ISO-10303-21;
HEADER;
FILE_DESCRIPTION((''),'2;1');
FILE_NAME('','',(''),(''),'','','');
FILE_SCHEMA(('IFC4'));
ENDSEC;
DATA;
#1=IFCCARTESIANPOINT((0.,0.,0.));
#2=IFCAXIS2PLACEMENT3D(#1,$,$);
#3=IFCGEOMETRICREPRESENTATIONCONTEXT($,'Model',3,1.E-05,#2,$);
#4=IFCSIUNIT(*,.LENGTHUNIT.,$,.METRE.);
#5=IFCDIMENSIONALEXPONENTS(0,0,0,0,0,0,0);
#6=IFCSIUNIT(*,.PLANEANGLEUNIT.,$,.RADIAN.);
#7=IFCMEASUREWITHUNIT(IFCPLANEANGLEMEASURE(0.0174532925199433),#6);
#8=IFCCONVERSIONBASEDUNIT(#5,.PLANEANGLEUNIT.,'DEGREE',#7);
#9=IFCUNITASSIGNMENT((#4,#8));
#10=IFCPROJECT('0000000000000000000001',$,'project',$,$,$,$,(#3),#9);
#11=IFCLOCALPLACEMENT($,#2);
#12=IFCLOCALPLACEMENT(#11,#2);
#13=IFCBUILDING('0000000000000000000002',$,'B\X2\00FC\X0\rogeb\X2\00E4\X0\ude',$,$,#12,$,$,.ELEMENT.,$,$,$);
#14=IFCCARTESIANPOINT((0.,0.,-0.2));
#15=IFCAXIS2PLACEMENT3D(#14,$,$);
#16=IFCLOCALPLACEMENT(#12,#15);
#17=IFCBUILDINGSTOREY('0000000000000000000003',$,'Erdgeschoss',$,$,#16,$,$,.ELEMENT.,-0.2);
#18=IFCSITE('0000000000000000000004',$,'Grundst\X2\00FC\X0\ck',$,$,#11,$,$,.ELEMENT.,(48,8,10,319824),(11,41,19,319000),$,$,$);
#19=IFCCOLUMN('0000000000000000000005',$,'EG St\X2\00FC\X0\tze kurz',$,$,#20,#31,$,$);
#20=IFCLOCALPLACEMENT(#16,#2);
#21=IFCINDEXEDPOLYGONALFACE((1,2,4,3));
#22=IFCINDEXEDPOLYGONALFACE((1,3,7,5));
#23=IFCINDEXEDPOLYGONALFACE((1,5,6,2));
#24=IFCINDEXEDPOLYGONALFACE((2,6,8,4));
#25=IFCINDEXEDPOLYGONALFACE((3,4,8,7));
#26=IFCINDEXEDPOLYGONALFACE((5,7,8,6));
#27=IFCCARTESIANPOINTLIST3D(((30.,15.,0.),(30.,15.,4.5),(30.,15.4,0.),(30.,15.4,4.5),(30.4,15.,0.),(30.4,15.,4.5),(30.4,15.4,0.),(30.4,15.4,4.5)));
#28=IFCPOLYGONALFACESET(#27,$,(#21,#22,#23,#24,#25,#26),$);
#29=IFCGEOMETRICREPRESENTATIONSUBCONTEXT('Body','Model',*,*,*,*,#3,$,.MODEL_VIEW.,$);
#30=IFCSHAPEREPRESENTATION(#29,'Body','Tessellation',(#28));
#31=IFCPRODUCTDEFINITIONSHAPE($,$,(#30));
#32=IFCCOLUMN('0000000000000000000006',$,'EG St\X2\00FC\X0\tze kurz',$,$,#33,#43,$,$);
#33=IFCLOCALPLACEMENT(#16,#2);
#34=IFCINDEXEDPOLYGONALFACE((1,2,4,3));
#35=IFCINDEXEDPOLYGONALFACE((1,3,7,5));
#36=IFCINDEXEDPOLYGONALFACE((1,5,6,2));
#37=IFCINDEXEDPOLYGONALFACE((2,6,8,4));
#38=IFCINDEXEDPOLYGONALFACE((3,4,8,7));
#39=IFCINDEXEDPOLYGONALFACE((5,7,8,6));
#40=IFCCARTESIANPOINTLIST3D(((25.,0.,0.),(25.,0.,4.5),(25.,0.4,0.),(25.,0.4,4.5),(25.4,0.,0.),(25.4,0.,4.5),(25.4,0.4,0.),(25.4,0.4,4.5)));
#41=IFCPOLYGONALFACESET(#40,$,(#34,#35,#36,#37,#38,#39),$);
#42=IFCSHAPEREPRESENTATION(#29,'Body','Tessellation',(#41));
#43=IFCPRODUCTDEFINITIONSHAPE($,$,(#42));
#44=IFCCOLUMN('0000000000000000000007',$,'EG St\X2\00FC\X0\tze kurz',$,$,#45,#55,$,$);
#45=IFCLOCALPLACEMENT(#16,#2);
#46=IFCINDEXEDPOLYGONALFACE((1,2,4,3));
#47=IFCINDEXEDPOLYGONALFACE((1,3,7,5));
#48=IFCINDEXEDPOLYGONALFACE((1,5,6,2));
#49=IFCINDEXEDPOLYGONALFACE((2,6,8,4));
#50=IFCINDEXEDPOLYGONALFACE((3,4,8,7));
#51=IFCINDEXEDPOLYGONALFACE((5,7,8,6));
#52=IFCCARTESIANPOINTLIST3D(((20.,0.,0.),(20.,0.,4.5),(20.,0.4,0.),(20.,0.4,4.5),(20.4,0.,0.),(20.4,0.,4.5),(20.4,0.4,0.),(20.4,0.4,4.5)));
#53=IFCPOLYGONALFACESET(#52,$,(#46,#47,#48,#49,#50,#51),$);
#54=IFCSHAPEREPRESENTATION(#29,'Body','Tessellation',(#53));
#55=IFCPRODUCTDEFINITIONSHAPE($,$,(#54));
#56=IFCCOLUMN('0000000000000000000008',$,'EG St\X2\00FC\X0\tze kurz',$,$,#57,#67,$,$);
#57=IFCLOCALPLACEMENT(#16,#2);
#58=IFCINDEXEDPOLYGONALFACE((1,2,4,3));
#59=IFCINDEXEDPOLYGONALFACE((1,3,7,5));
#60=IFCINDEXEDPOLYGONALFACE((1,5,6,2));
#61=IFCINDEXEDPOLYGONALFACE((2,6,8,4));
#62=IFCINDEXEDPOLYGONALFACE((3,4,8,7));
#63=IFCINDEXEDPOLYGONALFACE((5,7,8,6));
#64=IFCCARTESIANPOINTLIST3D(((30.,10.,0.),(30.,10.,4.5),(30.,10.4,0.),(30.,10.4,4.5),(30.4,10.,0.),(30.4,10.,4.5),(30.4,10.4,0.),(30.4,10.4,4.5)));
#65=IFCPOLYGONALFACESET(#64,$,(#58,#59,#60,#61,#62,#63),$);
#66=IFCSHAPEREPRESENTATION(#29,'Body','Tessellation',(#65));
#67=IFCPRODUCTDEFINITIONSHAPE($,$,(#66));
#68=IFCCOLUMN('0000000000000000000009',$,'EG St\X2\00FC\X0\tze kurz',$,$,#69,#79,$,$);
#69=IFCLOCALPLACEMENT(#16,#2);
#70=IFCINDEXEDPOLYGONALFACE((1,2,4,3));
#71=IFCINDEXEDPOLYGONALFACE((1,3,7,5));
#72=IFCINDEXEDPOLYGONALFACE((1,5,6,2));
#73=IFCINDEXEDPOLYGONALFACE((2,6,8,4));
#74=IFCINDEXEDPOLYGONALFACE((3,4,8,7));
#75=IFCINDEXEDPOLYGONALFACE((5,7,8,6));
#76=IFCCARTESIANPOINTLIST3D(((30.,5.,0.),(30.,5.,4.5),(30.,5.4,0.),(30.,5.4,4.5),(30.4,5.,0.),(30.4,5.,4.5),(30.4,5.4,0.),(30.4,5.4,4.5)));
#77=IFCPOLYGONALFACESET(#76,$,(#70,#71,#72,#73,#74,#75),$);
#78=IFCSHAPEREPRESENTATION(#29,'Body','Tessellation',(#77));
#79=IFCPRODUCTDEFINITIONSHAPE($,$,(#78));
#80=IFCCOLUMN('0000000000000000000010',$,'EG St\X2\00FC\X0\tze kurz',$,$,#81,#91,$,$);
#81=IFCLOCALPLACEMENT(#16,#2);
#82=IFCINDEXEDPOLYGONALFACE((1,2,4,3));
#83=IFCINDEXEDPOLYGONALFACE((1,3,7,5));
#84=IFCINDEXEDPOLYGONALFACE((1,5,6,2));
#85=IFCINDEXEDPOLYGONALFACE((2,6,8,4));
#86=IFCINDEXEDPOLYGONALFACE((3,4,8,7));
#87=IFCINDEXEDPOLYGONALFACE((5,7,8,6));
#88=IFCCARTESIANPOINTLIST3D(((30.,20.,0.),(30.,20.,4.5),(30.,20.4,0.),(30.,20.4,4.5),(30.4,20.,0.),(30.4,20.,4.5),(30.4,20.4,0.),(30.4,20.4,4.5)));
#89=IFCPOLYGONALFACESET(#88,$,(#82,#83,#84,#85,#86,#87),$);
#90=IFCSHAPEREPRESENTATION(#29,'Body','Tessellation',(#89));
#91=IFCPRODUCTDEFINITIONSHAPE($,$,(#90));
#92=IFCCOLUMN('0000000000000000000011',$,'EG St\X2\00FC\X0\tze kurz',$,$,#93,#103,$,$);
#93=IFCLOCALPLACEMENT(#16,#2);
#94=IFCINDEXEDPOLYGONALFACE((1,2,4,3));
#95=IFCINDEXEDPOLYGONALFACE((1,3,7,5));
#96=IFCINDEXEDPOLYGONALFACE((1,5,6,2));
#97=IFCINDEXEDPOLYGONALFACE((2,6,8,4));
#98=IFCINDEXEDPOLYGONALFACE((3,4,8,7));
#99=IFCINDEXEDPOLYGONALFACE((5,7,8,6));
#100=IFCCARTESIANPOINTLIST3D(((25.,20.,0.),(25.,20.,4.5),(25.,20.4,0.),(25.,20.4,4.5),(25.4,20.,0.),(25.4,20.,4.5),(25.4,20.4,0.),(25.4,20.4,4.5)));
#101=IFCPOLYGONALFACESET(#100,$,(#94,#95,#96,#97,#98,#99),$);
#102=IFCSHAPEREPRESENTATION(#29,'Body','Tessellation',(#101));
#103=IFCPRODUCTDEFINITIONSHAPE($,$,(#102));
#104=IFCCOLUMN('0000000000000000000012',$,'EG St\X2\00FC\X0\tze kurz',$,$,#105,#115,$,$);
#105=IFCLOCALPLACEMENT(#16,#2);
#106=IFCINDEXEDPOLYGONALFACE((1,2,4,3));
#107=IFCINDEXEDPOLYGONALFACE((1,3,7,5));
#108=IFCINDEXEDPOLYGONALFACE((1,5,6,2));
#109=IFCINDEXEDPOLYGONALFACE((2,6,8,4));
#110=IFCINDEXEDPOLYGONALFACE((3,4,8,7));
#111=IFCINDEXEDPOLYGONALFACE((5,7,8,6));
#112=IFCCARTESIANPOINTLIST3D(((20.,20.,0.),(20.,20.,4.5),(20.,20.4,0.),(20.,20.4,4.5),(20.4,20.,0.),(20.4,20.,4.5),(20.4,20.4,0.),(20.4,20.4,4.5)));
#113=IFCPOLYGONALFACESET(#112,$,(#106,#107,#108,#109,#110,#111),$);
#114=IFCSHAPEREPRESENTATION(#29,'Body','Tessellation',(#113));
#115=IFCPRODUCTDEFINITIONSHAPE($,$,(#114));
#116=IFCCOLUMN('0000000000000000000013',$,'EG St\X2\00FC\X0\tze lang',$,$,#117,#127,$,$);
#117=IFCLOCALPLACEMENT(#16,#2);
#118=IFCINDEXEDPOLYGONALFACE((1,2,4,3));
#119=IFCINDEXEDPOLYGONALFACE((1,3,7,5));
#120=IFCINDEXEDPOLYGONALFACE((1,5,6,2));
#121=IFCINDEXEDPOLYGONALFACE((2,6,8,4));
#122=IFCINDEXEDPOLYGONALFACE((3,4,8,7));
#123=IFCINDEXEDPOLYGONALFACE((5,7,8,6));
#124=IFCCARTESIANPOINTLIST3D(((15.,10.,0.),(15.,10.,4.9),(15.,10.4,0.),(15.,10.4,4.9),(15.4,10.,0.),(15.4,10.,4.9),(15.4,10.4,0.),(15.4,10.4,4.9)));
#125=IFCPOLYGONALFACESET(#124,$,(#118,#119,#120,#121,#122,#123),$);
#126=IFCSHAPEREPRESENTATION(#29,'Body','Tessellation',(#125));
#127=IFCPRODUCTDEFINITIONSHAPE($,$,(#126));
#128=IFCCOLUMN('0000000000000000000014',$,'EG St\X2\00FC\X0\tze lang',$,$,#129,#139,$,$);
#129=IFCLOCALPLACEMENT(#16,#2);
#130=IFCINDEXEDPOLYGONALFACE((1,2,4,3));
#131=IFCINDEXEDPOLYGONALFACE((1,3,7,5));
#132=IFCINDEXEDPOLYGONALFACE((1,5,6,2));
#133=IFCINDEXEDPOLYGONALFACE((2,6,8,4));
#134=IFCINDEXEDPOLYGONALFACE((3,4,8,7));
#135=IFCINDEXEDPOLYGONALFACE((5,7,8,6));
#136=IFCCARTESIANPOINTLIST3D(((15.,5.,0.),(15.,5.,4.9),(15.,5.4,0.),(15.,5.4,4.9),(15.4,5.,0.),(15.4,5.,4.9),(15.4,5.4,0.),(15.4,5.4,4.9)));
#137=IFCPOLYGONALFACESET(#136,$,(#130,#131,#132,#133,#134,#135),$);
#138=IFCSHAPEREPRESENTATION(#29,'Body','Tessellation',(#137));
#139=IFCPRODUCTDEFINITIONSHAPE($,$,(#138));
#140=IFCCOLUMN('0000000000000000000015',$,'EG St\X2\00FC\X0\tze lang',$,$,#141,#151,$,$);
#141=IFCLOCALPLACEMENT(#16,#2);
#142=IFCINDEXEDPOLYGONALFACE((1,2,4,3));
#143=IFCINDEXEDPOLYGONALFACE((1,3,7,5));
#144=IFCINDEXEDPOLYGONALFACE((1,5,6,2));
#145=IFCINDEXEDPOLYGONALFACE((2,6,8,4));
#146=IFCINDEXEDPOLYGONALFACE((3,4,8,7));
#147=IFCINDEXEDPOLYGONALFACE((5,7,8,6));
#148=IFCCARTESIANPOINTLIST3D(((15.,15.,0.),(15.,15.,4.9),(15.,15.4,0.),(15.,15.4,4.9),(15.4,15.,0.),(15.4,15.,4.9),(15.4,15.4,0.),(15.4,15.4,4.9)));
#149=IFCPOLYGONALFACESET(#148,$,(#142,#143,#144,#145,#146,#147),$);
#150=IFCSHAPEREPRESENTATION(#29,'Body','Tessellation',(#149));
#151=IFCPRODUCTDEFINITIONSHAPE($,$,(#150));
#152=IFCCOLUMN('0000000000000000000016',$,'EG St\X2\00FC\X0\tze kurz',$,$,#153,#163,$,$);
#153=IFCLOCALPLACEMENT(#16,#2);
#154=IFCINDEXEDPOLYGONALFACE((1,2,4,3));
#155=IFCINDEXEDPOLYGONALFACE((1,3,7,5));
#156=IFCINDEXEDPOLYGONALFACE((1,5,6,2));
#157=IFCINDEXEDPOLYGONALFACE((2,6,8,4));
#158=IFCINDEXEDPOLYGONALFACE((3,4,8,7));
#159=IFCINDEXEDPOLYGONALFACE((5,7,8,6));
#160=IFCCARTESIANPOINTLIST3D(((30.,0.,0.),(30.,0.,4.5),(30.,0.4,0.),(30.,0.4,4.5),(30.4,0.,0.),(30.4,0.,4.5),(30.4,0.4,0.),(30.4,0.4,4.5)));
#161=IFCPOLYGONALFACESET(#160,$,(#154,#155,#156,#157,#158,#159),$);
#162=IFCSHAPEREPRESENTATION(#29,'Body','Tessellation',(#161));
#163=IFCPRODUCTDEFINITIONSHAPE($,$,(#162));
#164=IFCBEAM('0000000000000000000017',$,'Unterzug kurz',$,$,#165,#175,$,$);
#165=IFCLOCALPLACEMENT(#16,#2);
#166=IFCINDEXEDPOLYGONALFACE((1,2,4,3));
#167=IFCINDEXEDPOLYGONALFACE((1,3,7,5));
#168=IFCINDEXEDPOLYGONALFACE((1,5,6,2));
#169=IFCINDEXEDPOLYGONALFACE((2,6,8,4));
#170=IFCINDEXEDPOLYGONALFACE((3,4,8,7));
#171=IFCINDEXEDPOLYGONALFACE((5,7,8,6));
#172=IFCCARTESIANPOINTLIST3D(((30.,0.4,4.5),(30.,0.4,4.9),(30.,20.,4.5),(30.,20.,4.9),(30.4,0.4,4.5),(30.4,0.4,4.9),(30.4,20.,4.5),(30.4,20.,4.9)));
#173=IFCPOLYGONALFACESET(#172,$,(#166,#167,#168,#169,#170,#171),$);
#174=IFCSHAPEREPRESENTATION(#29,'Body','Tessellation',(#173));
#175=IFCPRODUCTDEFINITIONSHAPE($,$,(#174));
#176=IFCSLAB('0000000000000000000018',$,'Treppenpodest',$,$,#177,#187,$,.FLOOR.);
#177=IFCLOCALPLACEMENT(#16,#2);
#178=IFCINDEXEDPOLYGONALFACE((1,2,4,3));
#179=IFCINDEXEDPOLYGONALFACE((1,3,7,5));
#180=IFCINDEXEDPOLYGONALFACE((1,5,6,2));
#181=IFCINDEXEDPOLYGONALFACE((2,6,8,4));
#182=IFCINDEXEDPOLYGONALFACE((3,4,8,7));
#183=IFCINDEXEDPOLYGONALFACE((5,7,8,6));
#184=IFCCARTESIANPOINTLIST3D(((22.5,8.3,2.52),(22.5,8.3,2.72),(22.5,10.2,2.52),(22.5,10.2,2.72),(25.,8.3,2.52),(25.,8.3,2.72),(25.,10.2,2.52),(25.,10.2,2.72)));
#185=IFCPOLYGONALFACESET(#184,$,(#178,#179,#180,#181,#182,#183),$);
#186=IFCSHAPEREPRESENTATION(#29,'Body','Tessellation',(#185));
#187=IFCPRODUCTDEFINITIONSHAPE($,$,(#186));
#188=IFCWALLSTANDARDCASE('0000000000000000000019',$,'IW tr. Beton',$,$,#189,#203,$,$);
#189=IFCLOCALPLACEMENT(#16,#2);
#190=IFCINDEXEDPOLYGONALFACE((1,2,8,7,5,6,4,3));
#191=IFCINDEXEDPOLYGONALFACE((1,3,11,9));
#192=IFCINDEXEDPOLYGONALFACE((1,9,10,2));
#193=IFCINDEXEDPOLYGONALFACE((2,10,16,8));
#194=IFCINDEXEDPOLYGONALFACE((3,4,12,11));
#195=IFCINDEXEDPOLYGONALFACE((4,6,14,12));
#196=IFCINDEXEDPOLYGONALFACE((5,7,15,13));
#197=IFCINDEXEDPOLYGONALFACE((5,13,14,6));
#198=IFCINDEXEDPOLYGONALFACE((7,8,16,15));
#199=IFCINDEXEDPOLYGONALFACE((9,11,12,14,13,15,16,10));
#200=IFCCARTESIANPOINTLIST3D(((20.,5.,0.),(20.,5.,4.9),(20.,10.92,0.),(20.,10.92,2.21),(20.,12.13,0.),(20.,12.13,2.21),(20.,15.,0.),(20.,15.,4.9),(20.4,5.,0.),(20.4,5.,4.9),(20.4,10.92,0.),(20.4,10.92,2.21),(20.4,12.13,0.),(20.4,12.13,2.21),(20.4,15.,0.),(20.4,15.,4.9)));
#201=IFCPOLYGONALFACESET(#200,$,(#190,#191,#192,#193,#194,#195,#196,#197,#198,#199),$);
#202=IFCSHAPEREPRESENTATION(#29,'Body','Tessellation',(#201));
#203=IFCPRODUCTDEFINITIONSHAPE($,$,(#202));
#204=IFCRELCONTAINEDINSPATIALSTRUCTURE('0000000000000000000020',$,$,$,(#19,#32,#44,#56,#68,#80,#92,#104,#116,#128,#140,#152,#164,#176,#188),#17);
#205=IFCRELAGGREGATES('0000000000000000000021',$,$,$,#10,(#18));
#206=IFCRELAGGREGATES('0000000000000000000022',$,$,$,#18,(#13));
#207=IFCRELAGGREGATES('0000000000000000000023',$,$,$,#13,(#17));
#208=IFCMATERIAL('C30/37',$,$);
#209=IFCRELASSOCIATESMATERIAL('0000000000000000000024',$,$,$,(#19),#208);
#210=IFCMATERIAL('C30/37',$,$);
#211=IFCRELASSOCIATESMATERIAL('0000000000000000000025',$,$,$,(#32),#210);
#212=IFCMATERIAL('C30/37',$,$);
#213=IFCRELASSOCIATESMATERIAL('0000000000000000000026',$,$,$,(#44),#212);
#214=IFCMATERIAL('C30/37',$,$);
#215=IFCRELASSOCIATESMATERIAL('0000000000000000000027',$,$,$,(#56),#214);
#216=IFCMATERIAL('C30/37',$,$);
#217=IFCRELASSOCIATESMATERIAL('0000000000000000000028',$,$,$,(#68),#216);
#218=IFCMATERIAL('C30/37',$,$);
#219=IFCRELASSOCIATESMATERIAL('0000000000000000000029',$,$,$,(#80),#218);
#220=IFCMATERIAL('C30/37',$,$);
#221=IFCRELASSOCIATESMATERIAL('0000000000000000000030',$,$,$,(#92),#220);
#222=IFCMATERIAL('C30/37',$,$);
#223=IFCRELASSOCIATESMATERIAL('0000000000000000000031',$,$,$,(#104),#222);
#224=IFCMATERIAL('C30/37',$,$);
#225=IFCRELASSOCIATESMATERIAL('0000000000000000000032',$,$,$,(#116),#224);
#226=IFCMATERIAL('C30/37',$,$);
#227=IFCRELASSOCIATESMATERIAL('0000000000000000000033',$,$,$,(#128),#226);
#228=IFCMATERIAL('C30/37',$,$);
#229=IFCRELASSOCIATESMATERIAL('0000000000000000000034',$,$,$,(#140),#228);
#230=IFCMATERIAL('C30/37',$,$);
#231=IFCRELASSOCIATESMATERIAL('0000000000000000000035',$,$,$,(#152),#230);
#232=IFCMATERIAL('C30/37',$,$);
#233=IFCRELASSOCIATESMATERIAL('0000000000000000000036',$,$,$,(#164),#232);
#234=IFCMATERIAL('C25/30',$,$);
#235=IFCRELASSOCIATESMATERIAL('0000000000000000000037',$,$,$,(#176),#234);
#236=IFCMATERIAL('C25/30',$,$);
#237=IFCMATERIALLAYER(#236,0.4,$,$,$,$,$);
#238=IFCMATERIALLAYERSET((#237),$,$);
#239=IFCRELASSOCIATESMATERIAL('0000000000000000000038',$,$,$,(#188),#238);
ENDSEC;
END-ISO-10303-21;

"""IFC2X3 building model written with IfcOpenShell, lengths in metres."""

from ifc_helpers import new_model, entity, si_unit, converted_unit, frame, frame_2d, origin, origin_with_axes, place, context, subcontext, project, spatial, polyline, rectangle, outline, extrude, material, layer, layer_set, layer_usage, element, save


model = new_model("IFC2X3")

# Units and contexts
model_context = context("Model", 3, precision=1e-05, world=origin())
body_context = subcontext(model_context, "Body", "Model", "MODEL_VIEW")
ifc_project = project(units=[si_unit("LENGTHUNIT", "METRE"), converted_unit("PLANEANGLEUNIT", "DEGREE", entity("IfcPlaneAngleMeasure", 0.0174532925199433), si_unit("PLANEANGLEUNIT", "RADIAN"), dimensions=[0, 0, 0, 0, 0, 0, 0])], contexts=[model_context])

# Site, building, storey
site_placement = place(None, origin())
site = spatial("IfcSite", under=ifc_project, at=site_placement, Name="Grundstück", CompositionType="ELEMENT", RefLatitude=(48, 8, 10, 319824), RefLongitude=(11, 41, 19, 319000))
building_placement = place(site_placement, origin())
building = spatial("IfcBuilding", under=site, at=building_placement, Name="Bürogebäude", CompositionType="ELEMENT")
storey_placement = place(building_placement, frame((0.0, 0.0, -0.2)))
storey = spatial("IfcBuildingStorey", under=building, at=storey_placement, Name="Erdgeschoss", CompositionType="ELEMENT", Elevation=-0.2)

# Columns
ifc_material_1 = material(Name="C30/37")
column_1_placement = place(storey_placement, frame((30.0, 15.0, 0.0)))
element("IfcColumn", 1, at=column_1_placement, inside=storey, material=ifc_material_1, Name="EG Stütze kurz", context=body_context, shape_type="SweptSolid", body=[
    extrude(rectangle(XDim=0.4, YDim=0.4, at=frame_2d((0.2, 0.2), x_axis=(1.0, 0.0))), origin_with_axes(), (0.0, 0.0, 1.0), 4.5),
])
ifc_material_2 = material(Name="C30/37")
column_2_placement = place(storey_placement, frame((25.0, 0.0, 0.0)))
element("IfcColumn", 2, at=column_2_placement, inside=storey, material=ifc_material_2, Name="EG Stütze kurz", context=body_context, shape_type="SweptSolid", body=[
    extrude(rectangle(XDim=0.4, YDim=0.4, at=frame_2d((0.2, 0.2), x_axis=(1.0, 0.0))), origin_with_axes(), (0.0, 0.0, 1.0), 4.5),
])
ifc_material_3 = material(Name="C30/37")
column_3_placement = place(storey_placement, frame((20.0, 0.0, 0.0)))
element("IfcColumn", 3, at=column_3_placement, inside=storey, material=ifc_material_3, Name="EG Stütze kurz", context=body_context, shape_type="SweptSolid", body=[
    extrude(rectangle(XDim=0.4, YDim=0.4, at=frame_2d((0.2, 0.2), x_axis=(1.0, 0.0))), origin_with_axes(), (0.0, 0.0, 1.0), 4.5),
])
ifc_material_4 = material(Name="C30/37")
column_4_placement = place(storey_placement, frame((30.0, 10.0, 0.0)))
element("IfcColumn", 4, at=column_4_placement, inside=storey, material=ifc_material_4, Name="EG Stütze kurz", context=body_context, shape_type="SweptSolid", body=[
    extrude(rectangle(XDim=0.4, YDim=0.4, at=frame_2d((0.2, 0.2), x_axis=(1.0, 0.0))), origin_with_axes(), (0.0, 0.0, 1.0), 4.5),
])
ifc_material_5 = material(Name="C30/37")
column_5_placement = place(storey_placement, frame((30.0, 5.0, 0.0)))
element("IfcColumn", 5, at=column_5_placement, inside=storey, material=ifc_material_5, Name="EG Stütze kurz", context=body_context, shape_type="SweptSolid", body=[
    extrude(rectangle(XDim=0.4, YDim=0.4, at=frame_2d((0.2, 0.2), x_axis=(1.0, 0.0))), origin_with_axes(), (0.0, 0.0, 1.0), 4.5),
])
ifc_material_6 = material(Name="C30/37")
column_6_placement = place(storey_placement, frame((30.0, 20.0, 0.0)))
element("IfcColumn", 6, at=column_6_placement, inside=storey, material=ifc_material_6, Name="EG Stütze kurz", context=body_context, shape_type="SweptSolid", body=[
    extrude(rectangle(XDim=0.4, YDim=0.4, at=frame_2d((0.2, 0.2), x_axis=(1.0, 0.0))), origin_with_axes(), (0.0, 0.0, 1.0), 4.5),
])
ifc_material_7 = material(Name="C30/37")
column_7_placement = place(storey_placement, frame((25.0, 20.0, 0.0)))
element("IfcColumn", 7, at=column_7_placement, inside=storey, material=ifc_material_7, Name="EG Stütze kurz", context=body_context, shape_type="SweptSolid", body=[
    extrude(rectangle(XDim=0.4, YDim=0.4, at=frame_2d((0.2, 0.2), x_axis=(1.0, 0.0))), origin_with_axes(), (0.0, 0.0, 1.0), 4.5),
])
ifc_material_8 = material(Name="C30/37")
column_8_placement = place(storey_placement, frame((20.0, 20.0, 0.0)))
element("IfcColumn", 8, at=column_8_placement, inside=storey, material=ifc_material_8, Name="EG Stütze kurz", context=body_context, shape_type="SweptSolid", body=[
    extrude(rectangle(XDim=0.4, YDim=0.4, at=frame_2d((0.2, 0.2), x_axis=(1.0, 0.0))), origin_with_axes(), (0.0, 0.0, 1.0), 4.5),
])
ifc_material_9 = material(Name="C30/37")
column_9_placement = place(storey_placement, frame((15.0, 10.0, 0.0)))
element("IfcColumn", 9, at=column_9_placement, inside=storey, material=ifc_material_9, Name="EG Stütze lang", context=body_context, shape_type="SweptSolid", body=[
    extrude(rectangle(XDim=0.4, YDim=0.4, at=frame_2d((0.2, 0.2), x_axis=(1.0, 0.0))), origin_with_axes(), (0.0, 0.0, 1.0), 4.9),
])
ifc_material_10 = material(Name="C30/37")
column_10_placement = place(storey_placement, frame((15.0, 5.0, 0.0)))
element("IfcColumn", 10, at=column_10_placement, inside=storey, material=ifc_material_10, Name="EG Stütze lang", context=body_context, shape_type="SweptSolid", body=[
    extrude(rectangle(XDim=0.4, YDim=0.4, at=frame_2d((0.2, 0.2), x_axis=(1.0, 0.0))), origin_with_axes(), (0.0, 0.0, 1.0), 4.9),
])
ifc_material_11 = material(Name="C30/37")
column_11_placement = place(storey_placement, frame((15.0, 15.0, 0.0)))
element("IfcColumn", 11, at=column_11_placement, inside=storey, material=ifc_material_11, Name="EG Stütze lang", context=body_context, shape_type="SweptSolid", body=[
    extrude(rectangle(XDim=0.4, YDim=0.4, at=frame_2d((0.2, 0.2), x_axis=(1.0, 0.0))), origin_with_axes(), (0.0, 0.0, 1.0), 4.9),
])
ifc_material_12 = material(Name="C30/37")
column_12_placement = place(storey_placement, frame((30.0, 0.0, 0.0)))
element("IfcColumn", 12, at=column_12_placement, inside=storey, material=ifc_material_12, Name="EG Stütze kurz", context=body_context, shape_type="SweptSolid", body=[
    extrude(rectangle(XDim=0.4, YDim=0.4, at=frame_2d((0.2, 0.2), x_axis=(1.0, 0.0))), origin_with_axes(), (0.0, 0.0, 1.0), 4.5),
])

# Beam
ifc_material_13 = material(Name="C30/37")
beam_placement = place(storey_placement, frame((30.4, 0.4, 4.5), z_axis=(0.0, 0.0, 1.0), x_axis=(0.0, 1.0, 0.0)))
element("IfcBeam", 13, at=beam_placement, inside=storey, material=ifc_material_13, Name="Unterzug kurz", context=body_context, shape_type="SweptSolid", body=[
    extrude(rectangle(XDim=0.4, YDim=0.4, at=frame_2d((0.2, 0.2), x_axis=(1.0, 0.0))), frame((0.0, 0.0, 0.0), z_axis=(1.0, 0.0, 0.0), x_axis=(0.0, 1.0, 0.0)), (0.0, 0.0, 1.0), 19.6),
])

# Slab
ifc_material_14 = material(Name="C25/30")
slab_placement = place(storey_placement, frame((22.5, 8.3, 2.52)))
element("IfcSlab", 14, at=slab_placement, inside=storey, material=ifc_material_14, Name="Treppenpodest", PredefinedType="FLOOR", context=body_context, shape_type="SweptSolid", body=[
    extrude(rectangle(XDim=2.5, YDim=1.9, at=frame_2d((1.25, 0.95), x_axis=(1.0, 0.0))), origin_with_axes(), (0.0, 0.0, 1.0), 0.2),
])

# Wall, opening
ifc_material_15 = material(Name="C25/30")
ifc_layer_1 = layer(ifc_material_15, 0.4)
ifc_layer_set_1 = layer_set([ifc_layer_1])
ifc_layer_usage_1 = layer_usage(ifc_layer_set_1, "AXIS2", "POSITIVE", -0.2)
wall_1_placement = place(storey_placement, frame((20.4, 5.0, 0.0), z_axis=(0.0, 0.0, 1.0), x_axis=(0.0, 1.0, 0.0)))
wall_1 = element("IfcWallStandardCase", 15, at=wall_1_placement, inside=storey, material=ifc_layer_usage_1, Name="IW tr. Beton", context=body_context, shape_type="SweptSolid", body=[
    extrude(rectangle(XDim=10.0, YDim=0.4, at=frame_2d((5.0, 0.2), x_axis=(1.0, 0.0))), origin_with_axes(), (0.0, 0.0, 1.0), 4.9),
])
opening_1_placement = place(wall_1_placement, frame((5.92, 0.0, 0.0), z_axis=(0.0, 1.0, 0.0), x_axis=(0.0, 0.0, 1.0)))
element("IfcOpeningElement", 16, at=opening_1_placement, cuts=wall_1, ObjectType="Opening", context=body_context, shape_type="SweptSolid", body=[
    extrude(outline(polyline([(0.0, 1.21), (2.21, 1.21), (2.21, 0.0), (0.0, 0.0), (0.0, 1.21)])), origin_with_axes(), (0.0, 0.0, 1.0), 0.4),
])

save(model, "model.ifc")
